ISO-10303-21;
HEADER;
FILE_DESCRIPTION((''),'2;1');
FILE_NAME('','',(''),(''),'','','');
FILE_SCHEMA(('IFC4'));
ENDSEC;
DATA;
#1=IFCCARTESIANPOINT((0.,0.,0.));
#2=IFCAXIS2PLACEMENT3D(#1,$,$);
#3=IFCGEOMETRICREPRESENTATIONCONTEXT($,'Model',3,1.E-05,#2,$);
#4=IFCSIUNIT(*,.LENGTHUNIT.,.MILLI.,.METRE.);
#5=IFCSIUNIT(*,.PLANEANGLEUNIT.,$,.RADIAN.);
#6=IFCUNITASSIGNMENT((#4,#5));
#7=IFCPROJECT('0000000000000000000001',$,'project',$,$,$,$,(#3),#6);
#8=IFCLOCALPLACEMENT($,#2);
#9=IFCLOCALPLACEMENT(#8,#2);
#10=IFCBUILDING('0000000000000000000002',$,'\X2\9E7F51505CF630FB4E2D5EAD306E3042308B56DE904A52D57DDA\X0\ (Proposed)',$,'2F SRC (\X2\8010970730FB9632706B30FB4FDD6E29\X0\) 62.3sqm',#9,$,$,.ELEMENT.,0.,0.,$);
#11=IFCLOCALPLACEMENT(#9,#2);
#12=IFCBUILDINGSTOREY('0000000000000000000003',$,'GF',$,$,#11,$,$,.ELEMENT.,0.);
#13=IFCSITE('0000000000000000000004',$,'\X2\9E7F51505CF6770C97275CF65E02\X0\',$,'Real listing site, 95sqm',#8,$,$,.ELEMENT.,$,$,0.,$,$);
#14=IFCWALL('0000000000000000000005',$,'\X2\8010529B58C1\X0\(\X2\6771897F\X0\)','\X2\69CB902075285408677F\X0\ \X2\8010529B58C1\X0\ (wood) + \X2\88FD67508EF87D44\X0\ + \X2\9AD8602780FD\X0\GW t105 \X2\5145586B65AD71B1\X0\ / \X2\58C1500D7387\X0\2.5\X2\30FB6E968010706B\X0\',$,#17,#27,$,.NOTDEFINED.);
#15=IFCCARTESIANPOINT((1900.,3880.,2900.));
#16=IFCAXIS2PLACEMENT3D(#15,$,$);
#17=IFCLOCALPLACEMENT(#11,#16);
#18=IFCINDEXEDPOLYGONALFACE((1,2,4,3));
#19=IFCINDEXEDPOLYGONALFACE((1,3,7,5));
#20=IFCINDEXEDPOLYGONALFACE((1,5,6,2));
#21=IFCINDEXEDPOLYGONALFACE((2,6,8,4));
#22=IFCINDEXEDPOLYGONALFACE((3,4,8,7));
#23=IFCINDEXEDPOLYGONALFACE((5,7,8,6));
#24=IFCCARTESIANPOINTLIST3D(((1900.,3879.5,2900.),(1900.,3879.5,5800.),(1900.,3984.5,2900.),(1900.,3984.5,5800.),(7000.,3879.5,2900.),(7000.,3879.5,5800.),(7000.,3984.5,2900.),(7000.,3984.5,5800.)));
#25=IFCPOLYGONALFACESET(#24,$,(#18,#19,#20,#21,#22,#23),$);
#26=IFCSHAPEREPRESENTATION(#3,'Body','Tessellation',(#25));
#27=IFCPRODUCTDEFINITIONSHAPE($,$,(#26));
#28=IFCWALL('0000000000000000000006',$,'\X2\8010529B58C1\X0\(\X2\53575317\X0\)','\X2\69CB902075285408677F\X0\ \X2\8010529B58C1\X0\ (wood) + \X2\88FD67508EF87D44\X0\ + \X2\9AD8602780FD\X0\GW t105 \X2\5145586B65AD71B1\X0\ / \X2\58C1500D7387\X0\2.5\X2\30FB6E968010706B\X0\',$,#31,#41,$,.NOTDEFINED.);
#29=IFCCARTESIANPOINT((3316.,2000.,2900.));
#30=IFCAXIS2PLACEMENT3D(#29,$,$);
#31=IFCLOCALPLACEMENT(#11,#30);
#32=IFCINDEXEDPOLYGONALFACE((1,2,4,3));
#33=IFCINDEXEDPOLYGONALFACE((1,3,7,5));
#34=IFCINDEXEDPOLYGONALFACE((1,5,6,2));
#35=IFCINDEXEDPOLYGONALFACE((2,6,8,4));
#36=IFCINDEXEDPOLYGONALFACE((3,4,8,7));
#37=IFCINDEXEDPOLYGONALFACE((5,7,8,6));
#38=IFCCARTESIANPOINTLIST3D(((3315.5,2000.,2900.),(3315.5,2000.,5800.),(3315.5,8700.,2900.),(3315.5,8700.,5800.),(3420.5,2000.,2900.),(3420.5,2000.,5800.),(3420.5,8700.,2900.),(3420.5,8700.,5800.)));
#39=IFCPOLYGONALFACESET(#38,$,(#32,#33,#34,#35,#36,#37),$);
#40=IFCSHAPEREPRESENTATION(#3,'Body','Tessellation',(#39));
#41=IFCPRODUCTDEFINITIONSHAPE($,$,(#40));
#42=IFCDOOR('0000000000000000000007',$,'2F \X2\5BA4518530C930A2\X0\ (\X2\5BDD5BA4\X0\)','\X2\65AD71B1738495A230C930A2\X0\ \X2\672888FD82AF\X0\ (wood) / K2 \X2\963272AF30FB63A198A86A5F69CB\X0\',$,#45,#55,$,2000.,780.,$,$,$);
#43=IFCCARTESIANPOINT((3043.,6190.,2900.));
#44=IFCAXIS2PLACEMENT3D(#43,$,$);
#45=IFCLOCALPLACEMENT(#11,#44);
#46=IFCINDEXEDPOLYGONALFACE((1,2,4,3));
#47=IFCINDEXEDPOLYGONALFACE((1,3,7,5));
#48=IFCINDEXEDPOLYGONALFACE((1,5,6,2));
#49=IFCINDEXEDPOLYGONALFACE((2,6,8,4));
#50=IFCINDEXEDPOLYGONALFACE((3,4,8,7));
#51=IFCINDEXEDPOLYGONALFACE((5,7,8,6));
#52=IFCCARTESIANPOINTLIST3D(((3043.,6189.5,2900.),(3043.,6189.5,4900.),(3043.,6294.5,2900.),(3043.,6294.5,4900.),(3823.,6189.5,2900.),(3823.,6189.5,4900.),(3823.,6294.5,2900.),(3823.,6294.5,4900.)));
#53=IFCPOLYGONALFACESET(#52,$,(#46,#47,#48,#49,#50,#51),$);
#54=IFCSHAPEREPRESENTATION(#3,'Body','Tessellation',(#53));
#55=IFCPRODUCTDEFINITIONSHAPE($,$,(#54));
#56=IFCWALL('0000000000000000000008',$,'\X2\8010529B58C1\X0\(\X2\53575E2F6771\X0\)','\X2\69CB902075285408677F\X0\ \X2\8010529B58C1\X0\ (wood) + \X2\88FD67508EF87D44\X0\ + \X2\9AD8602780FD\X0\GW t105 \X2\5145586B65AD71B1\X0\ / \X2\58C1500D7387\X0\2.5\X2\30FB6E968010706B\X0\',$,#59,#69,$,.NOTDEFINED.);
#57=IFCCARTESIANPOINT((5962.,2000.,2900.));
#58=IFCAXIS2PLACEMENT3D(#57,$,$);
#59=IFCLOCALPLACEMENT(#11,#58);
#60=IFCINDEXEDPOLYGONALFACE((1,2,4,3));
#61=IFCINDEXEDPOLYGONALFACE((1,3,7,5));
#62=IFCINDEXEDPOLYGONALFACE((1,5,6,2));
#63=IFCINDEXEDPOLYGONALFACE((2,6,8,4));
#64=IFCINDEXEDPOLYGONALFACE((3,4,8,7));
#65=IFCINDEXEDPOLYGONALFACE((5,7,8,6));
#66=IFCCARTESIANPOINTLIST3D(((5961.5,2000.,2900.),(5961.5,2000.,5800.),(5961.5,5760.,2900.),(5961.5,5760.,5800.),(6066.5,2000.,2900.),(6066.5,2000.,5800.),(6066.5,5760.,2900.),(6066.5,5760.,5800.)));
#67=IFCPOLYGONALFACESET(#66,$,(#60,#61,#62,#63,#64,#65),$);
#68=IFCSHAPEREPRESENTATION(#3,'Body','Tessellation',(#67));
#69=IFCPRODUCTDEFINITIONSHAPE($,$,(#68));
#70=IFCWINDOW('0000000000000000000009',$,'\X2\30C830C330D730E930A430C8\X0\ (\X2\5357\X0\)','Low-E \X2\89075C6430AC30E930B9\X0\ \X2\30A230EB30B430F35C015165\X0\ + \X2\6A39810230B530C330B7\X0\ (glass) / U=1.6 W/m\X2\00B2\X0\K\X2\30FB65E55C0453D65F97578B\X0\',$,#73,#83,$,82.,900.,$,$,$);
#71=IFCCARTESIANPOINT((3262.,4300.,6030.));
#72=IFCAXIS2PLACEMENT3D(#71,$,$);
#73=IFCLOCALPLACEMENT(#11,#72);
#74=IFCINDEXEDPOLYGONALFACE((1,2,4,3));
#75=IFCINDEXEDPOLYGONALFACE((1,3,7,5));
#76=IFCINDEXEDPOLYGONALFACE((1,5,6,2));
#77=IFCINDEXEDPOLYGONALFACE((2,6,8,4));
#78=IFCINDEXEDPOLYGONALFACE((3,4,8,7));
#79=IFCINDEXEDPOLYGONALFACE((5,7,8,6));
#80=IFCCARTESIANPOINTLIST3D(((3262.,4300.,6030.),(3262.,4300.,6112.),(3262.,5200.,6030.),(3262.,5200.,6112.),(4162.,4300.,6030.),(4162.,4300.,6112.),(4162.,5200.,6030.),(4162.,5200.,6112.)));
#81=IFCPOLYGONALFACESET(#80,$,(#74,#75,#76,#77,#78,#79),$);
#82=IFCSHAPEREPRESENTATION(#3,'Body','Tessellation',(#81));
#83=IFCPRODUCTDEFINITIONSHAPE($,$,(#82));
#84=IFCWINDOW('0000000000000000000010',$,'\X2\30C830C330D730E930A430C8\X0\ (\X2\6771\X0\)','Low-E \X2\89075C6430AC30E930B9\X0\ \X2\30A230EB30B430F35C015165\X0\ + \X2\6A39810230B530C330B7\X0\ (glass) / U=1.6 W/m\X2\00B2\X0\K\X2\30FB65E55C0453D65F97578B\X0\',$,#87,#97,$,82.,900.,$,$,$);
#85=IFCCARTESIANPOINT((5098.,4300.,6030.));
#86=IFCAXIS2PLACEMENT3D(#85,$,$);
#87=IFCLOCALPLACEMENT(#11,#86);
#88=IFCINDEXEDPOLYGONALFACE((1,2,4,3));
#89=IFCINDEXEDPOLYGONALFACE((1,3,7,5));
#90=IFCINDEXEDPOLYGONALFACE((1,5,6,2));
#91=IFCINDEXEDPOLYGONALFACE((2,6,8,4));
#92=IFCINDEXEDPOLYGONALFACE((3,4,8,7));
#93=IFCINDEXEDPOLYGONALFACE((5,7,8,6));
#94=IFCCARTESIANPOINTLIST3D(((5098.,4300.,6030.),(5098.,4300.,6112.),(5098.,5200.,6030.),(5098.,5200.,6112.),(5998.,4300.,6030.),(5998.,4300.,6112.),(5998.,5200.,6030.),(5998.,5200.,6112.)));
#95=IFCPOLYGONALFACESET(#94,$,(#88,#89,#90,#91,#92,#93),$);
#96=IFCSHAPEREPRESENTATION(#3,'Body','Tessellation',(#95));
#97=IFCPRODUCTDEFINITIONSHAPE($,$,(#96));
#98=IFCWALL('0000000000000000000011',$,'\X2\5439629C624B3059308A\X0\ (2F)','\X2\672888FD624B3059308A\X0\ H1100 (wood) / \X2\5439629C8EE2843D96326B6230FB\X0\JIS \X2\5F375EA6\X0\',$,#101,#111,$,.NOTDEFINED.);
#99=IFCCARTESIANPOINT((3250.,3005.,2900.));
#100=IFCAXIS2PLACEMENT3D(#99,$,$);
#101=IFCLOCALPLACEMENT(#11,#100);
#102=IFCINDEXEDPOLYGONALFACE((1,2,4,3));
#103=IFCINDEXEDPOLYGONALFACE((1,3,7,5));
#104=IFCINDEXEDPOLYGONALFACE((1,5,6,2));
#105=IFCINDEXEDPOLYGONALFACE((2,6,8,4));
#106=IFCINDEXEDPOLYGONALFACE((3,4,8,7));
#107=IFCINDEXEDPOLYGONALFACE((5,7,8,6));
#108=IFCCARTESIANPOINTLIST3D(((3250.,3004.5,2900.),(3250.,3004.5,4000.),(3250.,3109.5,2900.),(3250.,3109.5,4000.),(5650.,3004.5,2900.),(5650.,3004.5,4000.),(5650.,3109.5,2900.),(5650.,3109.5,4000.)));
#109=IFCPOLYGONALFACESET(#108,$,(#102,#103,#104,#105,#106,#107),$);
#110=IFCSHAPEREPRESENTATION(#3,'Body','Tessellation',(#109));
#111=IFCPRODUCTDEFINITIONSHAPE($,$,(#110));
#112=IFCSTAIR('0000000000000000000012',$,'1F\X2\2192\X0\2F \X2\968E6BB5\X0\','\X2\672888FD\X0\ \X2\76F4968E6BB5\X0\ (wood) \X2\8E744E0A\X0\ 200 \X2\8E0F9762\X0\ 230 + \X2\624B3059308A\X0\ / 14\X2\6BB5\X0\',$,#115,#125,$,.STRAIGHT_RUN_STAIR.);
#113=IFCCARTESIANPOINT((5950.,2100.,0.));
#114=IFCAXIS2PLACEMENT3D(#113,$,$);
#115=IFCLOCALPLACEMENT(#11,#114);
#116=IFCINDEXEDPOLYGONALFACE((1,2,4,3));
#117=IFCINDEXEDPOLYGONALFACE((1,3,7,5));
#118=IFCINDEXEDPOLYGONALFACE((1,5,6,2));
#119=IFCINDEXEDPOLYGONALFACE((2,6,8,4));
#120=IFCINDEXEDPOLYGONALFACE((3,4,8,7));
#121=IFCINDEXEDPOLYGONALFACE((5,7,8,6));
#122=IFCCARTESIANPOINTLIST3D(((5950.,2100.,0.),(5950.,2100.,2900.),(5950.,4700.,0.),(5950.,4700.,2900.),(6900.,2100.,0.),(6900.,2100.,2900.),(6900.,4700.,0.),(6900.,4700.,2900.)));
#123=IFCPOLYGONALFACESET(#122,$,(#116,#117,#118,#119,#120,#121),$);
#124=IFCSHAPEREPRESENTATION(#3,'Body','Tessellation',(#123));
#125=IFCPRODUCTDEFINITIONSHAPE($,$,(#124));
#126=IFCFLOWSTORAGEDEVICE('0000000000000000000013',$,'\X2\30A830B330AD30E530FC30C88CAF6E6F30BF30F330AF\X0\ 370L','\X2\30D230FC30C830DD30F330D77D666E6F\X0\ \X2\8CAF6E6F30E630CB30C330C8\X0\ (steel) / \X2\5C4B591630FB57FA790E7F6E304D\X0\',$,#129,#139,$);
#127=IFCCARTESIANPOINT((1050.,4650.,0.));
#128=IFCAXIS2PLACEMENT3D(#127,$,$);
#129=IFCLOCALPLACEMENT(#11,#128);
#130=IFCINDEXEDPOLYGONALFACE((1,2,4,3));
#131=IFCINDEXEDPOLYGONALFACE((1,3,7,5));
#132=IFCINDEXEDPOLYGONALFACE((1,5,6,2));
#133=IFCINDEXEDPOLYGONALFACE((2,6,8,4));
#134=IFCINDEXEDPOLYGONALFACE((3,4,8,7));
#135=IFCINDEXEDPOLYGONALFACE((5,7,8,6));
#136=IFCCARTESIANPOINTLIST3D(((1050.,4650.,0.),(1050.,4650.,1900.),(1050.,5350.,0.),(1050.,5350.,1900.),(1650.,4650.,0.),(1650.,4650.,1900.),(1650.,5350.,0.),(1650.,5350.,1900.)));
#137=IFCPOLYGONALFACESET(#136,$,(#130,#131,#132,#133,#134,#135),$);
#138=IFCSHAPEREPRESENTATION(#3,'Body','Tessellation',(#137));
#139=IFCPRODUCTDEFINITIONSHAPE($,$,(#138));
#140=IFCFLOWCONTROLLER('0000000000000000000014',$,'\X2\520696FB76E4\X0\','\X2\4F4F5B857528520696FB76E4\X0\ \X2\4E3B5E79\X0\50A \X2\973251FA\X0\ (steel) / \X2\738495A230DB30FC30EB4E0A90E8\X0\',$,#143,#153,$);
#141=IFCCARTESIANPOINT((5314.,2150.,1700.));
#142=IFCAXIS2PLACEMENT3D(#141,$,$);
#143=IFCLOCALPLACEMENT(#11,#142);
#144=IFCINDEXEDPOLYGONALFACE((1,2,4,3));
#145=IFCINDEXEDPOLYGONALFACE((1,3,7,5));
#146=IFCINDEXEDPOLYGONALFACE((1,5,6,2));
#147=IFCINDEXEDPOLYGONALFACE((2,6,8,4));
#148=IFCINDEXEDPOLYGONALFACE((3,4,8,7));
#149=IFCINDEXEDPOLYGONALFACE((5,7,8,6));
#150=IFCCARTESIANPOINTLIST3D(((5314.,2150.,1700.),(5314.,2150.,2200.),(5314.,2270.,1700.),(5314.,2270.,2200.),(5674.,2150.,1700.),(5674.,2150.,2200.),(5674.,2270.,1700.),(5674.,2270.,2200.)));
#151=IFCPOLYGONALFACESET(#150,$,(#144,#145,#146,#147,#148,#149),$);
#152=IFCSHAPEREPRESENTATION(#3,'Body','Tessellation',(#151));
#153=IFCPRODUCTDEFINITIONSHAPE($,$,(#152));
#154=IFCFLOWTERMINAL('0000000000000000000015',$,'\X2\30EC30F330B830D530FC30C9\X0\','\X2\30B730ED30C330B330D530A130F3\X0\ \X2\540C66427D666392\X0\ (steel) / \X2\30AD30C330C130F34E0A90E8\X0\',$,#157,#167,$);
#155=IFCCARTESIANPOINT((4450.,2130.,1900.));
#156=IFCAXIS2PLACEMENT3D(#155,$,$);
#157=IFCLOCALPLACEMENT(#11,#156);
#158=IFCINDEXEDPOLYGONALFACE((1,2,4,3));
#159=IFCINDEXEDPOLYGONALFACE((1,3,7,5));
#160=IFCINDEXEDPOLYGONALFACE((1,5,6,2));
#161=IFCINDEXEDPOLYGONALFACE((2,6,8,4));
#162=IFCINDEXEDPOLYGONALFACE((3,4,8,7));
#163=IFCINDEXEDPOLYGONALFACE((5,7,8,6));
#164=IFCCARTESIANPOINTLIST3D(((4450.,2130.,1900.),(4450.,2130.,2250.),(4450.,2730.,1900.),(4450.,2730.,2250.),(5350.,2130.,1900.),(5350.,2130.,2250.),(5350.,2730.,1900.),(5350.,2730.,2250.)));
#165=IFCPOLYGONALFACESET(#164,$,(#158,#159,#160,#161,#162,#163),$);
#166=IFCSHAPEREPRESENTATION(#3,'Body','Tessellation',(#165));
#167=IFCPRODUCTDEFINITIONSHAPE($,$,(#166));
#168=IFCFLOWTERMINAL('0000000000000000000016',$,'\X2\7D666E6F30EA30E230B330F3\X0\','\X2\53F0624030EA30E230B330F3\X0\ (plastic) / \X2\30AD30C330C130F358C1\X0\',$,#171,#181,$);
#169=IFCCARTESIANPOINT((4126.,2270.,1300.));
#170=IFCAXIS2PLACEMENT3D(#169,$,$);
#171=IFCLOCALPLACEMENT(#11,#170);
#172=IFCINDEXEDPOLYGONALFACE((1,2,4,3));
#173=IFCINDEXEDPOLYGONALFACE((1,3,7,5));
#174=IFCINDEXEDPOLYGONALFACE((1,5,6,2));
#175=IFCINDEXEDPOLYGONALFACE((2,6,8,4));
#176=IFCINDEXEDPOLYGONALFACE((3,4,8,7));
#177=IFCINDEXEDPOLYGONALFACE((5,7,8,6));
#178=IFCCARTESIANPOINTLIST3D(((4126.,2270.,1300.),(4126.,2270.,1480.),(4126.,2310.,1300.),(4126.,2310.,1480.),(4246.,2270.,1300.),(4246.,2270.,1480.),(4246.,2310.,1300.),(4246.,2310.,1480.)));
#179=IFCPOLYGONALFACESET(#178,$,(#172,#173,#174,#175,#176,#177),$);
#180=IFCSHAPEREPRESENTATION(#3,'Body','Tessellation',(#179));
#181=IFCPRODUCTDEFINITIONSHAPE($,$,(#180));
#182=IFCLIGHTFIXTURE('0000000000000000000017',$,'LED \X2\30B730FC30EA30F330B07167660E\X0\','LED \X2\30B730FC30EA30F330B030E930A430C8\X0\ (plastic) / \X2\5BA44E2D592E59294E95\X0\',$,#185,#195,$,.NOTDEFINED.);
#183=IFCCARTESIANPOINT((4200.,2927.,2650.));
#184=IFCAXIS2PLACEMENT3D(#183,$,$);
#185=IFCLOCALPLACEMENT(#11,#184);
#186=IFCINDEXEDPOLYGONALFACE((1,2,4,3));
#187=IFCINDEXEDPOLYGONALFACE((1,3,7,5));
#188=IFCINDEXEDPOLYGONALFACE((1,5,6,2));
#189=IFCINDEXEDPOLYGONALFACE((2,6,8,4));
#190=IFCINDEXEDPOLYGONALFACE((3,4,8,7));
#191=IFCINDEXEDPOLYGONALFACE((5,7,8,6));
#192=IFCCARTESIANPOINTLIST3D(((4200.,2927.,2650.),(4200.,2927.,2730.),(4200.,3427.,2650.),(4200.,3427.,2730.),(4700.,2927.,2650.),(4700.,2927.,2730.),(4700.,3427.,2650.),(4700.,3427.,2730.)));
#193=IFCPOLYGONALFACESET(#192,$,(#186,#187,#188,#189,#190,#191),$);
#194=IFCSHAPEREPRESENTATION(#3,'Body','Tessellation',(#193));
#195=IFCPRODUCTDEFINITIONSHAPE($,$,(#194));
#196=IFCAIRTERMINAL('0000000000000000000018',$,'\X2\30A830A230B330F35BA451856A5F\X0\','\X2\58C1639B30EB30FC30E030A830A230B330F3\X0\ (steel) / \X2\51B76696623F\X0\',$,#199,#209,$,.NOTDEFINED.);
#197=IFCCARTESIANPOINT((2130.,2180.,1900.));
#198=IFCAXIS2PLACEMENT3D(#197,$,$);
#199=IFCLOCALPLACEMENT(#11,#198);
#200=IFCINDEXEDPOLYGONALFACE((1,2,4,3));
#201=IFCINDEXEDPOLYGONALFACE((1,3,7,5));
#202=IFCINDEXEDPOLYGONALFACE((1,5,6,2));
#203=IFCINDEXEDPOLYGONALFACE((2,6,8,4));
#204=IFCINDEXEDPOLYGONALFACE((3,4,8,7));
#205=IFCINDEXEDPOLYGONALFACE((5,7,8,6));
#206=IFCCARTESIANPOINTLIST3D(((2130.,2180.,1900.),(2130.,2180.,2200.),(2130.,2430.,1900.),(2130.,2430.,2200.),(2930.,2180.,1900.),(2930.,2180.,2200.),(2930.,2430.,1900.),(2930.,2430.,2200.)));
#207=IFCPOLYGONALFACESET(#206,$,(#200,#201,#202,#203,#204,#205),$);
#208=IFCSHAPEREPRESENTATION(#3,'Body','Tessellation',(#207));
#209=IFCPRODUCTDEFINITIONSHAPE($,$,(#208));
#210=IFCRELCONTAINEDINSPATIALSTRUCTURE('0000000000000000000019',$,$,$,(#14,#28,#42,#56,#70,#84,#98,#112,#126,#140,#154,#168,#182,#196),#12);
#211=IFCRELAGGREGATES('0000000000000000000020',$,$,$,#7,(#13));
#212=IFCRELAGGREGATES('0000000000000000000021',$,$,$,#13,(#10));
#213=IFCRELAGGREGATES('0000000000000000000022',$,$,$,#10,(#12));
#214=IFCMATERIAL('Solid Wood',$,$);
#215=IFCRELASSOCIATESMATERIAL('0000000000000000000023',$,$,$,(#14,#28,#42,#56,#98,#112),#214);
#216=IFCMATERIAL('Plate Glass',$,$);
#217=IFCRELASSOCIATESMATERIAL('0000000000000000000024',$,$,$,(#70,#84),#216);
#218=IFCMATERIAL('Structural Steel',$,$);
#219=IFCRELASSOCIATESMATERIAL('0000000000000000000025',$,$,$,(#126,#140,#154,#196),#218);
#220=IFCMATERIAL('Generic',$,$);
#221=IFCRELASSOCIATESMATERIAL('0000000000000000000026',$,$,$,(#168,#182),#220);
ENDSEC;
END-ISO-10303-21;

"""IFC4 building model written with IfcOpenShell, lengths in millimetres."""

from ifc_helpers import new_model, si_unit, frame, frame_2d, origin, place, context, project, spatial, rectangle, extrude, material, element, fill, save


model = new_model("IFC4")

# Units and contexts
model_context = context("Model", 3, precision=1e-05, world=origin())
ifc_project = project(units=[si_unit("LENGTHUNIT", "METRE", prefix="MILLI"), si_unit("PLANEANGLEUNIT", "RADIAN")], contexts=[model_context])

# Site, building, storey
site_placement = place(None, origin())
site = spatial("IfcSite", under=ifc_project, at=site_placement, Name="鹿児島県霧島市", ObjectType="Real listing site, 95sqm", CompositionType="ELEMENT", RefElevation=0.0)
building_placement = place(site_placement, origin())
building = spatial("IfcBuilding", under=site, at=building_placement, Name="鹿児島・中庭のある回遊動線 (Proposed)", ObjectType="2F SRC (耐震・防火・保温) 62.3sqm", CompositionType="ELEMENT", ElevationOfRefHeight=0.0, ElevationOfTerrain=0.0)
storey_placement = place(building_placement, origin())
storey = spatial("IfcBuildingStorey", under=building, at=storey_placement, Name="GF", CompositionType="ELEMENT", Elevation=0.0)

# Shared definitions
ifc_material_1 = material(Name="Solid Wood")

# Wall
wall_1_placement = place(storey_placement, frame((1900.0, 3880.0, 2900.0)))
element("IfcWall", 1, at=wall_1_placement, inside=storey, material=ifc_material_1, Name="耐力壁(東西)", Description="構造用合板 耐力壁 (wood) + 製材軸組 + 高性能GW t105 充填断熱 / 壁倍率2.5・準耐火", PredefinedType="NOTDEFINED", context=model_context, shape_type="SweptSolid", body=[
    extrude(rectangle(XDim=5100.0, YDim=105.0, at=frame_2d((2550.0, 52.0))), frame((1900.0, 3880.0, 2900.0)), (0.0, 0.0, 1.0), 2900.0),
])

# Wall, opening, door
wall_2_placement = place(storey_placement, frame((3316.0, 2000.0, 2900.0)))
wall_2 = element("IfcWall", 2, at=wall_2_placement, inside=storey, material=ifc_material_1, Name="耐力壁(南北)", Description="構造用合板 耐力壁 (wood) + 製材軸組 + 高性能GW t105 充填断熱 / 壁倍率2.5・準耐火", PredefinedType="NOTDEFINED", context=model_context, shape_type="SweptSolid", body=[
    extrude(rectangle(XDim=105.0, YDim=6700.0, at=frame_2d((52.0, 3350.0))), frame((3316.0, 2000.0, 2900.0)), (0.0, 0.0, 1.0), 2900.0),
])
opening_placement = place(storey_placement, frame((3043.0, 6190.0, 2900.0)))
opening = element("IfcOpeningElement", 3, at=opening_placement, cuts=wall_2, PredefinedType="NOTDEFINED", context=model_context, shape_type="SweptSolid", body=[
    extrude(rectangle(XDim=780.0, YDim=105.0, at=frame_2d((390.0, 52.0))), frame((3043.0, 6190.0, 2900.0)), (0.0, 0.0, 1.0), 2000.0),
])
door_placement = place(storey_placement, frame((3043.0, 6190.0, 2900.0)))
door = element("IfcDoor", 4, at=door_placement, inside=storey, material=ifc_material_1, Name="2F 室内ドア (寝室)", Description="断熱玄関ドア 木製芯 (wood) / K2 防犯・採風機構", OverallHeight=2000.0, OverallWidth=780.0, context=model_context, shape_type="SweptSolid", body=[
    extrude(rectangle(XDim=780.0, YDim=105.0, at=frame_2d((390.0, 52.0))), frame((3043.0, 6190.0, 2900.0)), (0.0, 0.0, 1.0), 2000.0),
])
fill(opening, door)

# Wall
wall_3_placement = place(storey_placement, frame((5962.0, 2000.0, 2900.0)))
element("IfcWall", 5, at=wall_3_placement, inside=storey, material=ifc_material_1, Name="耐力壁(南帯東)", Description="構造用合板 耐力壁 (wood) + 製材軸組 + 高性能GW t105 充填断熱 / 壁倍率2.5・準耐火", PredefinedType="NOTDEFINED", context=model_context, shape_type="SweptSolid", body=[
    extrude(rectangle(XDim=105.0, YDim=3760.0, at=frame_2d((52.0, 1880.0))), frame((5962.0, 2000.0, 2900.0)), (0.0, 0.0, 1.0), 2900.0),
])

# Windows
ifc_material_2 = material(Name="Plate Glass")
window_1_placement = place(storey_placement, frame((3262.0, 4300.0, 6030.0)))
element("IfcWindow", 6, at=window_1_placement, inside=storey, material=ifc_material_2, Name="トップライト (南)", Description="Low-E 複層ガラス アルゴン封入 + 樹脂サッシ (glass) / U=1.6 W/m²K・日射取得型", OverallHeight=82.0, OverallWidth=900.0, context=model_context, shape_type="SweptSolid", body=[
    extrude(rectangle(XDim=900.0, YDim=900.0, at=frame_2d((450.0, 450.0))), frame((3262.0, 4300.0, 6030.0)), (0.0, 0.0, 1.0), 82.0),
])
window_2_placement = place(storey_placement, frame((5098.0, 4300.0, 6030.0)))
element("IfcWindow", 7, at=window_2_placement, inside=storey, material=ifc_material_2, Name="トップライト (東)", Description="Low-E 複層ガラス アルゴン封入 + 樹脂サッシ (glass) / U=1.6 W/m²K・日射取得型", OverallHeight=82.0, OverallWidth=900.0, context=model_context, shape_type="SweptSolid", body=[
    extrude(rectangle(XDim=900.0, YDim=900.0, at=frame_2d((450.0, 450.0))), frame((5098.0, 4300.0, 6030.0)), (0.0, 0.0, 1.0), 82.0),
])

# Wall
wall_4_placement = place(storey_placement, frame((3250.0, 3005.0, 2900.0)))
element("IfcWall", 8, at=wall_4_placement, inside=storey, material=ifc_material_1, Name="吹抜手すり (2F)", Description="木製手すり H1100 (wood) / 吹抜転落防止・JIS 強度", PredefinedType="NOTDEFINED", context=model_context, shape_type="SweptSolid", body=[
    extrude(rectangle(XDim=2400.0, YDim=105.0, at=frame_2d((1200.0, 52.0))), frame((3250.0, 3005.0, 2900.0)), (0.0, 0.0, 1.0), 1100.0),
])

# Stair
stair_placement = place(storey_placement, frame((5950.0, 2100.0, 0.0)))
element("IfcStair", 9, at=stair_placement, inside=storey, material=ifc_material_1, Name="1F→2F 階段", Description="木製 直階段 (wood) 蹴上 200 踏面 230 + 手すり / 14段", PredefinedType="STRAIGHT_RUN_STAIR", context=model_context, shape_type="SweptSolid", body=[
    extrude(rectangle(XDim=950.0, YDim=2600.0, at=frame_2d((475.0, 1300.0))), frame((5950.0, 2100.0, 0.0)), (0.0, 0.0, 1.0), 2900.0),
])

# Flow storage device
ifc_material_3 = material(Name="Structural Steel")
flow_storage_device_placement = place(storey_placement, frame((1050.0, 4650.0, 0.0)))
element("IfcFlowStorageDevice", 10, at=flow_storage_device_placement, inside=storey, material=ifc_material_3, Name="エコキュート貯湯タンク 370L", Description="ヒートポンプ給湯 貯湯ユニット (steel) / 屋外・基礎置き", context=model_context, shape_type="SweptSolid", body=[
    extrude(rectangle(XDim=600.0, YDim=700.0, at=frame_2d((300.0, 350.0))), frame((1050.0, 4650.0, 0.0)), (0.0, 0.0, 1.0), 1900.0),
])

# Flow controller
flow_controller_placement = place(storey_placement, frame((5314.0, 2150.0, 1700.0)))
element("IfcFlowController", 11, at=flow_controller_placement, inside=storey, material=ifc_material_3, Name="分電盤", Description="住宅用分電盤 主幹50A 露出 (steel) / 玄関ホール上部", context=model_context, shape_type="SweptSolid", body=[
    extrude(rectangle(XDim=360.0, YDim=120.0, at=frame_2d((180.0, 60.0))), frame((5314.0, 2150.0, 1700.0)), (0.0, 0.0, 1.0), 500.0),
])

# Flow terminals
flow_terminal_1_placement = place(storey_placement, frame((4450.0, 2130.0, 1900.0)))
element("IfcFlowTerminal", 12, at=flow_terminal_1_placement, inside=storey, material=ifc_material_3, Name="レンジフード", Description="シロッコファン 同時給排 (steel) / キッチン上部", context=model_context, shape_type="SweptSolid", body=[
    extrude(rectangle(XDim=900.0, YDim=600.0, at=frame_2d((450.0, 300.0))), frame((4450.0, 2130.0, 1900.0)), (0.0, 0.0, 1.0), 350.0),
])
ifc_material_4 = material(Name="Generic")
flow_terminal_2_placement = place(storey_placement, frame((4126.0, 2270.0, 1300.0)))
element("IfcFlowTerminal", 13, at=flow_terminal_2_placement, inside=storey, material=ifc_material_4, Name="給湯リモコン", Description="台所リモコン (plastic) / キッチン壁", context=model_context, shape_type="SweptSolid", body=[
    extrude(rectangle(XDim=120.0, YDim=40.0, at=frame_2d((60.0, 20.0))), frame((4126.0, 2270.0, 1300.0)), (0.0, 0.0, 1.0), 180.0),
])

# Light fixture
light_fixture_1_placement = place(storey_placement, frame((4200.0, 2927.0, 2650.0)))
element("IfcLightFixture", 14, at=light_fixture_1_placement, inside=storey, material=ifc_material_4, Name="LED シーリング照明", Description="LED シーリングライト (plastic) / 室中央天井", PredefinedType="NOTDEFINED", context=model_context, shape_type="SweptSolid", body=[
    extrude(rectangle(XDim=500.0, YDim=500.0, at=frame_2d((250.0, 250.0))), frame((4200.0, 2927.0, 2650.0)), (0.0, 0.0, 1.0), 80.0),
])

# Air terminal
air_terminal_1_placement = place(storey_placement, frame((2130.0, 2180.0, 1900.0)))
element("IfcAirTerminal", 15, at=air_terminal_1_placement, inside=storey, material=ifc_material_3, Name="エアコン室内機", Description="壁掛ルームエアコン (steel) / 冷暖房", PredefinedType="NOTDEFINED", context=model_context, shape_type="SweptSolid", body=[
    extrude(rectangle(XDim=800.0, YDim=250.0, at=frame_2d((400.0, 125.0))), frame((2130.0, 2180.0, 1900.0)), (0.0, 0.0, 1.0), 300.0),
])

save(model, "model.ifc")
